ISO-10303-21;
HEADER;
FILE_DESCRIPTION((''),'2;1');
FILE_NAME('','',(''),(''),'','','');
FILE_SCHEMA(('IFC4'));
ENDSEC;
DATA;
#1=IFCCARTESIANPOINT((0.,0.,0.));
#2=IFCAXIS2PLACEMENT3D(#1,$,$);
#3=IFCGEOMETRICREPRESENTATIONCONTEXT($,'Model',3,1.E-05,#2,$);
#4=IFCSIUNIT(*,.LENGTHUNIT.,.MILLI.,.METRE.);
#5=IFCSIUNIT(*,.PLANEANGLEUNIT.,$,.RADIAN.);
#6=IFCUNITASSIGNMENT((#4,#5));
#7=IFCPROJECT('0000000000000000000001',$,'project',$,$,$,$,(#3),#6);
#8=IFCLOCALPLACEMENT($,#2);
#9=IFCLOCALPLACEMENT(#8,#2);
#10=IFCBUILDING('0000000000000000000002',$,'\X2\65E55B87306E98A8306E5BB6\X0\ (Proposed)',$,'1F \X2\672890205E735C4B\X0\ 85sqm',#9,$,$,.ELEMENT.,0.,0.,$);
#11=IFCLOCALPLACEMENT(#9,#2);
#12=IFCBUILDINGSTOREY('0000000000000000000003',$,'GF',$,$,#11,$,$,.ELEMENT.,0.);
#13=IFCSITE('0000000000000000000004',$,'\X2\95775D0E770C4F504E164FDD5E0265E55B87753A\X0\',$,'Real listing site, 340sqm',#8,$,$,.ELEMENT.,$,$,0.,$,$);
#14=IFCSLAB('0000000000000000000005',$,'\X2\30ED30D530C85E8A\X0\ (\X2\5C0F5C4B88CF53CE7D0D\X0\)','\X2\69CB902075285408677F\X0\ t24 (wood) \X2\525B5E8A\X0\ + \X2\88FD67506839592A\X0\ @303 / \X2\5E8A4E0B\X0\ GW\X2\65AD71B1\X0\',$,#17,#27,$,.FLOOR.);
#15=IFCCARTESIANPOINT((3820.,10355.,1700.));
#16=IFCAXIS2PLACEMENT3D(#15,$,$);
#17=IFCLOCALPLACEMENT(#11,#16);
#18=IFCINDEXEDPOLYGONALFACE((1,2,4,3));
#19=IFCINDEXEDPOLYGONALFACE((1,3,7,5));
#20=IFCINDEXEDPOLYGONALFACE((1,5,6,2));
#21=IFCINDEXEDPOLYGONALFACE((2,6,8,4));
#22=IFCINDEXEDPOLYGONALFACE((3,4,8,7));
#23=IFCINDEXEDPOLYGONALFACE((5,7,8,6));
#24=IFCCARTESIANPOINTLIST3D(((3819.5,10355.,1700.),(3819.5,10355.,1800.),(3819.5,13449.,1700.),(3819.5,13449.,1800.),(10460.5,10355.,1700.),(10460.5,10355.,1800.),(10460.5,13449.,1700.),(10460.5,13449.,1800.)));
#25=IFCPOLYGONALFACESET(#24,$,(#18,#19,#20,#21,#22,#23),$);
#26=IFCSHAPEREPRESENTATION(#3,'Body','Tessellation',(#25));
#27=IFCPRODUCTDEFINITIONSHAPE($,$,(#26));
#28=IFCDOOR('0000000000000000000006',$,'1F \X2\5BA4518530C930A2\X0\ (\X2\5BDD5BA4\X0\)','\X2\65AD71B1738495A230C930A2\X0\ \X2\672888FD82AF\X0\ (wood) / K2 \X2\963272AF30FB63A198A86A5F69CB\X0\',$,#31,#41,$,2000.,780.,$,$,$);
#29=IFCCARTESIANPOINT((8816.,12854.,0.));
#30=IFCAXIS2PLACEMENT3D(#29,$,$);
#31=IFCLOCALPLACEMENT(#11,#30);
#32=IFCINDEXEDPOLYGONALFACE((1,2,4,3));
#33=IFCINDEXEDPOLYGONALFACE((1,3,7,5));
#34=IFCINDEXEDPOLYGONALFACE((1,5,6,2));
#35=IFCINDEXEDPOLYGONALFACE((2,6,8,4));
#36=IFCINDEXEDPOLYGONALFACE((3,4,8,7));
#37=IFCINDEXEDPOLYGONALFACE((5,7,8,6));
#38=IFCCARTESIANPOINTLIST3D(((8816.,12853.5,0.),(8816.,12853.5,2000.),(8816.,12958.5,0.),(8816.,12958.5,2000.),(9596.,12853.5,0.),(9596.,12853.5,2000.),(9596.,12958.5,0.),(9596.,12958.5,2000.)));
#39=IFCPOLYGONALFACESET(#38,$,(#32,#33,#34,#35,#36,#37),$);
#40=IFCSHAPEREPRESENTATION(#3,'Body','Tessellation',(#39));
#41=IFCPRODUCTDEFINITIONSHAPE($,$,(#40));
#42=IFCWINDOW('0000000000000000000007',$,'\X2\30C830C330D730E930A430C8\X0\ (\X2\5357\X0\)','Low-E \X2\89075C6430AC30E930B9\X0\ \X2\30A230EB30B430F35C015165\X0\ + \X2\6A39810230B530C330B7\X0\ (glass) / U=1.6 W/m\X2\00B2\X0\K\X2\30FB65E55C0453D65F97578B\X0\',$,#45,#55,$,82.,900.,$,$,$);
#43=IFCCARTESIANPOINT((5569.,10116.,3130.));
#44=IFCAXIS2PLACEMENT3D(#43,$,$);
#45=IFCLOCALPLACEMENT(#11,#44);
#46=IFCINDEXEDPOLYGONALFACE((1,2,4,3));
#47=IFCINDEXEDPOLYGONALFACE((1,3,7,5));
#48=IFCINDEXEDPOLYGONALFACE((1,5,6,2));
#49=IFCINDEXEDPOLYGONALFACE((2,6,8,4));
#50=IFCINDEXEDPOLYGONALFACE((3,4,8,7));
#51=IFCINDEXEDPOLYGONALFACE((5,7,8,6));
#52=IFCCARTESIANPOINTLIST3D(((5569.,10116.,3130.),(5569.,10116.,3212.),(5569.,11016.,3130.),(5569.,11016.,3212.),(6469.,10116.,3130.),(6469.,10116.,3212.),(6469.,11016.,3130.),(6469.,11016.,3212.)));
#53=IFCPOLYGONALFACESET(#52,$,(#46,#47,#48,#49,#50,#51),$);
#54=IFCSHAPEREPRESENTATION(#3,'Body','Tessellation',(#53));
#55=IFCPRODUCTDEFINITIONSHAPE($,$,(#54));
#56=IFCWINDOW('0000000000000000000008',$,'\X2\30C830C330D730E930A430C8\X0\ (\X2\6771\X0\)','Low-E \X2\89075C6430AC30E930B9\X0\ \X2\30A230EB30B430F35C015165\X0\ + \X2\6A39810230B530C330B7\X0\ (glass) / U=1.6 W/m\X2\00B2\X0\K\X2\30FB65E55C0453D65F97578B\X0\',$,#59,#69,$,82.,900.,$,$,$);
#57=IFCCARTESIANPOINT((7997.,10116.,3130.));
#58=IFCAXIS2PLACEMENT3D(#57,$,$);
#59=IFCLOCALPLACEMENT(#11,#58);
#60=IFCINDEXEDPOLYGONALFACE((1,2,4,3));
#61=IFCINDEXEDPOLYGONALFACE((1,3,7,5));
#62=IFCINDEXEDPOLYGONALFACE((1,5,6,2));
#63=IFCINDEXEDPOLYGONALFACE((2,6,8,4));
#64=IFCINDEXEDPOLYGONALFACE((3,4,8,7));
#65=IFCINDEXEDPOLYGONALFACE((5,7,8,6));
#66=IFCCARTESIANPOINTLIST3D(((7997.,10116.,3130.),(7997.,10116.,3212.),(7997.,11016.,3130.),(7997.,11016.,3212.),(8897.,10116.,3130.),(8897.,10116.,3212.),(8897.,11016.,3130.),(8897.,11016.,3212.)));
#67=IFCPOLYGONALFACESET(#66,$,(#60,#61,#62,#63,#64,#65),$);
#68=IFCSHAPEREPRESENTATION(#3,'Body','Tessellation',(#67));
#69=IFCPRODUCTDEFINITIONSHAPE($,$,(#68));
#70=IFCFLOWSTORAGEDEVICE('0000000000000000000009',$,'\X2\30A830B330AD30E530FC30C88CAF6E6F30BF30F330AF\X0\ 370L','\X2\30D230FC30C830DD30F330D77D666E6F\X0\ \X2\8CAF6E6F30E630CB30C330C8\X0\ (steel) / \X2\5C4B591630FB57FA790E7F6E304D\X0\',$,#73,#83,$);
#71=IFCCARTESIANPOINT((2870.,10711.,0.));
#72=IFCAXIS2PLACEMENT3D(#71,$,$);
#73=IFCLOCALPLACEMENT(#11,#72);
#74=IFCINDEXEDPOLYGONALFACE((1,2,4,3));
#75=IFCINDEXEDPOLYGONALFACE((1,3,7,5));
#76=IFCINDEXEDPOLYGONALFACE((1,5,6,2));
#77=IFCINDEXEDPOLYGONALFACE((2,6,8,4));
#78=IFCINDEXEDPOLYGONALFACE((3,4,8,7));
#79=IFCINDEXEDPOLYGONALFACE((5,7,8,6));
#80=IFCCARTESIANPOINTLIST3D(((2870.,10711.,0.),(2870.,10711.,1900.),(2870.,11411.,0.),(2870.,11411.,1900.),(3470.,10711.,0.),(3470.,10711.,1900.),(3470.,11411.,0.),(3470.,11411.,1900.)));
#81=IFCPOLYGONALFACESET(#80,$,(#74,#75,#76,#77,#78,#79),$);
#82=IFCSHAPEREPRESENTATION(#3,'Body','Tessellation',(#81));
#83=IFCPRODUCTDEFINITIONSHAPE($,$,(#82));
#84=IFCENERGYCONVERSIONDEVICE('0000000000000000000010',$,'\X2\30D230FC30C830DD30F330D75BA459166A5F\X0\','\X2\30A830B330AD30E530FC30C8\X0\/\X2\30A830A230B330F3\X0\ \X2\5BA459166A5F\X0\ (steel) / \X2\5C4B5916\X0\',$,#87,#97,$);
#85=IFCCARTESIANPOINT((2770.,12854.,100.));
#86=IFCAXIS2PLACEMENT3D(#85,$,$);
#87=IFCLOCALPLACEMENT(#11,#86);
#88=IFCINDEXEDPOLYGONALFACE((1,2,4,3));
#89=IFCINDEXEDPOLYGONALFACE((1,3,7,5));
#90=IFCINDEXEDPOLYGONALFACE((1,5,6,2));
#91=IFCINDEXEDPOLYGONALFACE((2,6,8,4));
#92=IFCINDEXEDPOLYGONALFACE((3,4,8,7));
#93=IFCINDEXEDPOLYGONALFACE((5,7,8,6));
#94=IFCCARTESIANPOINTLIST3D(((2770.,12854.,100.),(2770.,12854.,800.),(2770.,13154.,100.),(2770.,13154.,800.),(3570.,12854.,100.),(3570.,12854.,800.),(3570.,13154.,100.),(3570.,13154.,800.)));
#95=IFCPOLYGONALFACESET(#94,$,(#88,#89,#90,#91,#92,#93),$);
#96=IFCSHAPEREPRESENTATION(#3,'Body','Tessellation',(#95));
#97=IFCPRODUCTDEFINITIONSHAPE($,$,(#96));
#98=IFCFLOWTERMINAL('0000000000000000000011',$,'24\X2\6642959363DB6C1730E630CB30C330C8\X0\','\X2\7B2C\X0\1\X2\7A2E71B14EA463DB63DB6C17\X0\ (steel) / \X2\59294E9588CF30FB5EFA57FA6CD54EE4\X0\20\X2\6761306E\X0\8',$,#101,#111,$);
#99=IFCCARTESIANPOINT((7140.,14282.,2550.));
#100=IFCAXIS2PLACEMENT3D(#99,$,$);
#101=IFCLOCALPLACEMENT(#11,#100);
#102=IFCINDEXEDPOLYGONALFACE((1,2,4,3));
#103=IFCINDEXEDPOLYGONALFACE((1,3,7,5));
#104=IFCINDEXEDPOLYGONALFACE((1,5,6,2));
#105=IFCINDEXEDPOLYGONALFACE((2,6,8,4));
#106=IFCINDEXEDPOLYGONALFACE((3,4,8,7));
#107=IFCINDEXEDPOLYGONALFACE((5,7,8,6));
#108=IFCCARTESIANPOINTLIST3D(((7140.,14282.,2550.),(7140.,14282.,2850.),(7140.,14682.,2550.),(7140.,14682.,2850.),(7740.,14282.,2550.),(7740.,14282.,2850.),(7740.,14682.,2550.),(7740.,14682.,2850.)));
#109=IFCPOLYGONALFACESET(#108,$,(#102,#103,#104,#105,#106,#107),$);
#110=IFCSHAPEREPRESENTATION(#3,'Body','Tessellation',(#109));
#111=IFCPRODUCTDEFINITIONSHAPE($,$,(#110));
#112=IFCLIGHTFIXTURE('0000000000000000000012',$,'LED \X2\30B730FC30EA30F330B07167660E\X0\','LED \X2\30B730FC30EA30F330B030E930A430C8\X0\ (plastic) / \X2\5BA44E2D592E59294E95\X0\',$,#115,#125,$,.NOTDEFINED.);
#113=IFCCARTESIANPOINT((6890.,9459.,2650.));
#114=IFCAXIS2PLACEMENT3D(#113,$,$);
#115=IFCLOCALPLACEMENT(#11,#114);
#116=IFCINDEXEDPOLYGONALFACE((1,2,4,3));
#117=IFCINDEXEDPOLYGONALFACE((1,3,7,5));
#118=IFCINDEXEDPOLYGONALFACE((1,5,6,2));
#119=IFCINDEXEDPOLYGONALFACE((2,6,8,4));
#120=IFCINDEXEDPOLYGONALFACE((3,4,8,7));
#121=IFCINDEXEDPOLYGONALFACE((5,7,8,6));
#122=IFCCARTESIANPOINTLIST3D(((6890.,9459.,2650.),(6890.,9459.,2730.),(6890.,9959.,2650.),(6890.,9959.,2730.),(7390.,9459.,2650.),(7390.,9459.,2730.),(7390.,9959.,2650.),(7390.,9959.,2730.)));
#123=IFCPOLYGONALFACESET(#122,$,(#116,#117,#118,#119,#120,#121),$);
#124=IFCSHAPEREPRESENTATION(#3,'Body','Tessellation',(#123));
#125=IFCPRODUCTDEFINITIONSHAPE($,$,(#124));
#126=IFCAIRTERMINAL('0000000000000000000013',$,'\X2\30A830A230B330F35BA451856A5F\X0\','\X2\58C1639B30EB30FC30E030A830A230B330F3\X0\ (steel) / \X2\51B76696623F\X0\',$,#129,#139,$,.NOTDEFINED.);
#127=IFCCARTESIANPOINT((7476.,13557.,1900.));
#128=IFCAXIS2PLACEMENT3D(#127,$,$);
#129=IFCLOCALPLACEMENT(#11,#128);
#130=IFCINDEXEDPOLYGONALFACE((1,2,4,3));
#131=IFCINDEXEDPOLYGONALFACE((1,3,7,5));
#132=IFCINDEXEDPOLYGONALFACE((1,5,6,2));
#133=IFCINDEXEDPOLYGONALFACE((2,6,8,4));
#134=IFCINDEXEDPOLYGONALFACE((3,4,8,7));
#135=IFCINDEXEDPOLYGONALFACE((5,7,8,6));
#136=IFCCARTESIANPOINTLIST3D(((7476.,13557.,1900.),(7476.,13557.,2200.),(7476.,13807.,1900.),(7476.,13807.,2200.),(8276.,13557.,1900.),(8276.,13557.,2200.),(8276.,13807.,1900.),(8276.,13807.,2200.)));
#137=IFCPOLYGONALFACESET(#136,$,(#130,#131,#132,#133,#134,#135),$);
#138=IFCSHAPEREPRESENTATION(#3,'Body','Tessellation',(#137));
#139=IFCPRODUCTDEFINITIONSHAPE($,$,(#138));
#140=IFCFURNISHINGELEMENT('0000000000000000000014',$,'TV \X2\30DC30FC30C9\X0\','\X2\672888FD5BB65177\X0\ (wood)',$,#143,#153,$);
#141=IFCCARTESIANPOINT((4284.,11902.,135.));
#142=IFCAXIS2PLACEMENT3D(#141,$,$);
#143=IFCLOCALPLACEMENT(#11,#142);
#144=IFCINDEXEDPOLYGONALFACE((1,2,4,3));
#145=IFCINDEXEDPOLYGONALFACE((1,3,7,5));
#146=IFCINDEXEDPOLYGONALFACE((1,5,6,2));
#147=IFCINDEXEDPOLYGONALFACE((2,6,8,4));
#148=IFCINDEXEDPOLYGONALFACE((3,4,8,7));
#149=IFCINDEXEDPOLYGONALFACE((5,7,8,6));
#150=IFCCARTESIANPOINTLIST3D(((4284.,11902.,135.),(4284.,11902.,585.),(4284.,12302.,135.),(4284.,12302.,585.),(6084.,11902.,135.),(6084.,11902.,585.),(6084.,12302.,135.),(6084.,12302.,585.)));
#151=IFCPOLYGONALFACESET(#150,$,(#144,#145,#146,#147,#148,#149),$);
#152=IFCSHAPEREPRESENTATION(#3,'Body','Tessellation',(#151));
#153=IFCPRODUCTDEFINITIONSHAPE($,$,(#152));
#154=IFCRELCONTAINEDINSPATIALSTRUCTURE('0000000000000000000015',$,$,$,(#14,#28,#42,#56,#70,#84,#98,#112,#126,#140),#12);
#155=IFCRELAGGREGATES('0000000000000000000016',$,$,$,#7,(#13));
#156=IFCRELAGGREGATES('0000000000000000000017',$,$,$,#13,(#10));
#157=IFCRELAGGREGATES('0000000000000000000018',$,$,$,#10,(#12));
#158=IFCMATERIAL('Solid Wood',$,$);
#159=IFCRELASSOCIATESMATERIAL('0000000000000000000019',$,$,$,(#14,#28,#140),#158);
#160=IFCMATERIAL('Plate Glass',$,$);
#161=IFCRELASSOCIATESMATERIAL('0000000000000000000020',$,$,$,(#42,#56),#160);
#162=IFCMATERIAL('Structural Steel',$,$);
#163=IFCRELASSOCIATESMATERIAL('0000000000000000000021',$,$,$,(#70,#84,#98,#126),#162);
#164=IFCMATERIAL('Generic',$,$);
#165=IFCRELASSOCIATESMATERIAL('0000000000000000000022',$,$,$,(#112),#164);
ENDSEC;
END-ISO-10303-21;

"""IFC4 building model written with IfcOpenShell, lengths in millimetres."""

from ifc_helpers import new_model, si_unit, frame, frame_2d, origin, place, context, project, spatial, rectangle, extrude, material, element, save


model = new_model("IFC4")

# Units and contexts
model_context = context("Model", 3, precision=1e-05, world=origin())
ifc_project = project(units=[si_unit("LENGTHUNIT", "METRE", prefix="MILLI"), si_unit("PLANEANGLEUNIT", "RADIAN")], contexts=[model_context])

# Site, building, storey
site_placement = place(None, origin())
site = spatial("IfcSite", under=ifc_project, at=site_placement, Name="長崎県佐世保市日宇町", ObjectType="Real listing site, 340sqm", CompositionType="ELEMENT", RefElevation=0.0)
building_placement = place(site_placement, origin())
building = spatial("IfcBuilding", under=site, at=building_placement, Name="日宇の風の家 (Proposed)", ObjectType="1F 木造平屋 85sqm", CompositionType="ELEMENT", ElevationOfRefHeight=0.0, ElevationOfTerrain=0.0)
storey_placement = place(building_placement, origin())
storey = spatial("IfcBuildingStorey", under=building, at=storey_placement, Name="GF", CompositionType="ELEMENT", Elevation=0.0)

# Shared definitions
ifc_material_1 = material(Name="Solid Wood")

# Slab
slab_placement = place(storey_placement, frame((3820.0, 10355.0, 1700.0)))
element("IfcSlab", 1, at=slab_placement, inside=storey, material=ifc_material_1, Name="ロフト床 (小屋裏収納)", Description="構造用合板 t24 (wood) 剛床 + 製材根太 @303 / 床下 GW断熱", PredefinedType="FLOOR", context=model_context, shape_type="SweptSolid", body=[
    extrude(rectangle(XDim=6641.0, YDim=3094.0, at=frame_2d((3320.0, 1547.0))), frame((3820.0, 10355.0, 1700.0)), (0.0, 0.0, 1.0), 100.0),
])

# Door
door_1_placement = place(storey_placement, frame((8816.0, 12854.0, 0.0)))
element("IfcDoor", 2, at=door_1_placement, inside=storey, material=ifc_material_1, Name="1F 室内ドア (寝室)", Description="断熱玄関ドア 木製芯 (wood) / K2 防犯・採風機構", OverallHeight=2000.0, OverallWidth=780.0, context=model_context, shape_type="SweptSolid", body=[
    extrude(rectangle(XDim=780.0, YDim=105.0, at=frame_2d((390.0, 52.0))), frame((8816.0, 12854.0, 0.0)), (0.0, 0.0, 1.0), 2000.0),
])

# Windows
ifc_material_2 = material(Name="Plate Glass")
window_1_placement = place(storey_placement, frame((5569.0, 10116.0, 3130.0)))
element("IfcWindow", 3, at=window_1_placement, inside=storey, material=ifc_material_2, Name="トップライト (南)", Description="Low-E 複層ガラス アルゴン封入 + 樹脂サッシ (glass) / U=1.6 W/m²K・日射取得型", OverallHeight=82.0, OverallWidth=900.0, context=model_context, shape_type="SweptSolid", body=[
    extrude(rectangle(XDim=900.0, YDim=900.0, at=frame_2d((450.0, 450.0))), frame((5569.0, 10116.0, 3130.0)), (0.0, 0.0, 1.0), 82.0),
])
window_2_placement = place(storey_placement, frame((7997.0, 10116.0, 3130.0)))
element("IfcWindow", 4, at=window_2_placement, inside=storey, material=ifc_material_2, Name="トップライト (東)", Description="Low-E 複層ガラス アルゴン封入 + 樹脂サッシ (glass) / U=1.6 W/m²K・日射取得型", OverallHeight=82.0, OverallWidth=900.0, context=model_context, shape_type="SweptSolid", body=[
    extrude(rectangle(XDim=900.0, YDim=900.0, at=frame_2d((450.0, 450.0))), frame((7997.0, 10116.0, 3130.0)), (0.0, 0.0, 1.0), 82.0),
])

# Flow storage device
ifc_material_3 = material(Name="Structural Steel")
flow_storage_device_placement = place(storey_placement, frame((2870.0, 10711.0, 0.0)))
element("IfcFlowStorageDevice", 5, at=flow_storage_device_placement, inside=storey, material=ifc_material_3, Name="エコキュート貯湯タンク 370L", Description="ヒートポンプ給湯 貯湯ユニット (steel) / 屋外・基礎置き", context=model_context, shape_type="SweptSolid", body=[
    extrude(rectangle(XDim=600.0, YDim=700.0, at=frame_2d((300.0, 350.0))), frame((2870.0, 10711.0, 0.0)), (0.0, 0.0, 1.0), 1900.0),
])

# Energy conversion device
energy_conversion_device_placement = place(storey_placement, frame((2770.0, 12854.0, 100.0)))
element("IfcEnergyConversionDevice", 6, at=energy_conversion_device_placement, inside=storey, material=ifc_material_3, Name="ヒートポンプ室外機", Description="エコキュート/エアコン 室外機 (steel) / 屋外", context=model_context, shape_type="SweptSolid", body=[
    extrude(rectangle(XDim=800.0, YDim=300.0, at=frame_2d((400.0, 150.0))), frame((2770.0, 12854.0, 100.0)), (0.0, 0.0, 1.0), 700.0),
])

# Flow terminal
flow_terminal_placement = place(storey_placement, frame((7140.0, 14282.0, 2550.0)))
element("IfcFlowTerminal", 7, at=flow_terminal_placement, inside=storey, material=ifc_material_3, Name="24時間換気ユニット", Description="第1種熱交換換気 (steel) / 天井裏・建基法令20条の8", context=model_context, shape_type="SweptSolid", body=[
    extrude(rectangle(XDim=600.0, YDim=400.0, at=frame_2d((300.0, 200.0))), frame((7140.0, 14282.0, 2550.0)), (0.0, 0.0, 1.0), 300.0),
])

# Light fixture
ifc_material_4 = material(Name="Generic")
light_fixture_placement = place(storey_placement, frame((6890.0, 9459.0, 2650.0)))
element("IfcLightFixture", 8, at=light_fixture_placement, inside=storey, material=ifc_material_4, Name="LED シーリング照明", Description="LED シーリングライト (plastic) / 室中央天井", PredefinedType="NOTDEFINED", context=model_context, shape_type="SweptSolid", body=[
    extrude(rectangle(XDim=500.0, YDim=500.0, at=frame_2d((250.0, 250.0))), frame((6890.0, 9459.0, 2650.0)), (0.0, 0.0, 1.0), 80.0),
])

# Air terminal
air_terminal_placement = place(storey_placement, frame((7476.0, 13557.0, 1900.0)))
element("IfcAirTerminal", 9, at=air_terminal_placement, inside=storey, material=ifc_material_3, Name="エアコン室内機", Description="壁掛ルームエアコン (steel) / 冷暖房", PredefinedType="NOTDEFINED", context=model_context, shape_type="SweptSolid", body=[
    extrude(rectangle(XDim=800.0, YDim=250.0, at=frame_2d((400.0, 125.0))), frame((7476.0, 13557.0, 1900.0)), (0.0, 0.0, 1.0), 300.0),
])

# Furnishing element
furnishing_placement = place(storey_placement, frame((4284.0, 11902.0, 135.0)))
element("IfcFurnishingElement", 10, at=furnishing_placement, inside=storey, material=ifc_material_1, Name="TV ボード", Description="木製家具 (wood)", context=model_context, shape_type="SweptSolid", body=[
    extrude(rectangle(XDim=1800.0, YDim=400.0, at=frame_2d((900.0, 200.0))), frame((4284.0, 11902.0, 135.0)), (0.0, 0.0, 1.0), 450.0),
])

save(model, "model.ifc")
